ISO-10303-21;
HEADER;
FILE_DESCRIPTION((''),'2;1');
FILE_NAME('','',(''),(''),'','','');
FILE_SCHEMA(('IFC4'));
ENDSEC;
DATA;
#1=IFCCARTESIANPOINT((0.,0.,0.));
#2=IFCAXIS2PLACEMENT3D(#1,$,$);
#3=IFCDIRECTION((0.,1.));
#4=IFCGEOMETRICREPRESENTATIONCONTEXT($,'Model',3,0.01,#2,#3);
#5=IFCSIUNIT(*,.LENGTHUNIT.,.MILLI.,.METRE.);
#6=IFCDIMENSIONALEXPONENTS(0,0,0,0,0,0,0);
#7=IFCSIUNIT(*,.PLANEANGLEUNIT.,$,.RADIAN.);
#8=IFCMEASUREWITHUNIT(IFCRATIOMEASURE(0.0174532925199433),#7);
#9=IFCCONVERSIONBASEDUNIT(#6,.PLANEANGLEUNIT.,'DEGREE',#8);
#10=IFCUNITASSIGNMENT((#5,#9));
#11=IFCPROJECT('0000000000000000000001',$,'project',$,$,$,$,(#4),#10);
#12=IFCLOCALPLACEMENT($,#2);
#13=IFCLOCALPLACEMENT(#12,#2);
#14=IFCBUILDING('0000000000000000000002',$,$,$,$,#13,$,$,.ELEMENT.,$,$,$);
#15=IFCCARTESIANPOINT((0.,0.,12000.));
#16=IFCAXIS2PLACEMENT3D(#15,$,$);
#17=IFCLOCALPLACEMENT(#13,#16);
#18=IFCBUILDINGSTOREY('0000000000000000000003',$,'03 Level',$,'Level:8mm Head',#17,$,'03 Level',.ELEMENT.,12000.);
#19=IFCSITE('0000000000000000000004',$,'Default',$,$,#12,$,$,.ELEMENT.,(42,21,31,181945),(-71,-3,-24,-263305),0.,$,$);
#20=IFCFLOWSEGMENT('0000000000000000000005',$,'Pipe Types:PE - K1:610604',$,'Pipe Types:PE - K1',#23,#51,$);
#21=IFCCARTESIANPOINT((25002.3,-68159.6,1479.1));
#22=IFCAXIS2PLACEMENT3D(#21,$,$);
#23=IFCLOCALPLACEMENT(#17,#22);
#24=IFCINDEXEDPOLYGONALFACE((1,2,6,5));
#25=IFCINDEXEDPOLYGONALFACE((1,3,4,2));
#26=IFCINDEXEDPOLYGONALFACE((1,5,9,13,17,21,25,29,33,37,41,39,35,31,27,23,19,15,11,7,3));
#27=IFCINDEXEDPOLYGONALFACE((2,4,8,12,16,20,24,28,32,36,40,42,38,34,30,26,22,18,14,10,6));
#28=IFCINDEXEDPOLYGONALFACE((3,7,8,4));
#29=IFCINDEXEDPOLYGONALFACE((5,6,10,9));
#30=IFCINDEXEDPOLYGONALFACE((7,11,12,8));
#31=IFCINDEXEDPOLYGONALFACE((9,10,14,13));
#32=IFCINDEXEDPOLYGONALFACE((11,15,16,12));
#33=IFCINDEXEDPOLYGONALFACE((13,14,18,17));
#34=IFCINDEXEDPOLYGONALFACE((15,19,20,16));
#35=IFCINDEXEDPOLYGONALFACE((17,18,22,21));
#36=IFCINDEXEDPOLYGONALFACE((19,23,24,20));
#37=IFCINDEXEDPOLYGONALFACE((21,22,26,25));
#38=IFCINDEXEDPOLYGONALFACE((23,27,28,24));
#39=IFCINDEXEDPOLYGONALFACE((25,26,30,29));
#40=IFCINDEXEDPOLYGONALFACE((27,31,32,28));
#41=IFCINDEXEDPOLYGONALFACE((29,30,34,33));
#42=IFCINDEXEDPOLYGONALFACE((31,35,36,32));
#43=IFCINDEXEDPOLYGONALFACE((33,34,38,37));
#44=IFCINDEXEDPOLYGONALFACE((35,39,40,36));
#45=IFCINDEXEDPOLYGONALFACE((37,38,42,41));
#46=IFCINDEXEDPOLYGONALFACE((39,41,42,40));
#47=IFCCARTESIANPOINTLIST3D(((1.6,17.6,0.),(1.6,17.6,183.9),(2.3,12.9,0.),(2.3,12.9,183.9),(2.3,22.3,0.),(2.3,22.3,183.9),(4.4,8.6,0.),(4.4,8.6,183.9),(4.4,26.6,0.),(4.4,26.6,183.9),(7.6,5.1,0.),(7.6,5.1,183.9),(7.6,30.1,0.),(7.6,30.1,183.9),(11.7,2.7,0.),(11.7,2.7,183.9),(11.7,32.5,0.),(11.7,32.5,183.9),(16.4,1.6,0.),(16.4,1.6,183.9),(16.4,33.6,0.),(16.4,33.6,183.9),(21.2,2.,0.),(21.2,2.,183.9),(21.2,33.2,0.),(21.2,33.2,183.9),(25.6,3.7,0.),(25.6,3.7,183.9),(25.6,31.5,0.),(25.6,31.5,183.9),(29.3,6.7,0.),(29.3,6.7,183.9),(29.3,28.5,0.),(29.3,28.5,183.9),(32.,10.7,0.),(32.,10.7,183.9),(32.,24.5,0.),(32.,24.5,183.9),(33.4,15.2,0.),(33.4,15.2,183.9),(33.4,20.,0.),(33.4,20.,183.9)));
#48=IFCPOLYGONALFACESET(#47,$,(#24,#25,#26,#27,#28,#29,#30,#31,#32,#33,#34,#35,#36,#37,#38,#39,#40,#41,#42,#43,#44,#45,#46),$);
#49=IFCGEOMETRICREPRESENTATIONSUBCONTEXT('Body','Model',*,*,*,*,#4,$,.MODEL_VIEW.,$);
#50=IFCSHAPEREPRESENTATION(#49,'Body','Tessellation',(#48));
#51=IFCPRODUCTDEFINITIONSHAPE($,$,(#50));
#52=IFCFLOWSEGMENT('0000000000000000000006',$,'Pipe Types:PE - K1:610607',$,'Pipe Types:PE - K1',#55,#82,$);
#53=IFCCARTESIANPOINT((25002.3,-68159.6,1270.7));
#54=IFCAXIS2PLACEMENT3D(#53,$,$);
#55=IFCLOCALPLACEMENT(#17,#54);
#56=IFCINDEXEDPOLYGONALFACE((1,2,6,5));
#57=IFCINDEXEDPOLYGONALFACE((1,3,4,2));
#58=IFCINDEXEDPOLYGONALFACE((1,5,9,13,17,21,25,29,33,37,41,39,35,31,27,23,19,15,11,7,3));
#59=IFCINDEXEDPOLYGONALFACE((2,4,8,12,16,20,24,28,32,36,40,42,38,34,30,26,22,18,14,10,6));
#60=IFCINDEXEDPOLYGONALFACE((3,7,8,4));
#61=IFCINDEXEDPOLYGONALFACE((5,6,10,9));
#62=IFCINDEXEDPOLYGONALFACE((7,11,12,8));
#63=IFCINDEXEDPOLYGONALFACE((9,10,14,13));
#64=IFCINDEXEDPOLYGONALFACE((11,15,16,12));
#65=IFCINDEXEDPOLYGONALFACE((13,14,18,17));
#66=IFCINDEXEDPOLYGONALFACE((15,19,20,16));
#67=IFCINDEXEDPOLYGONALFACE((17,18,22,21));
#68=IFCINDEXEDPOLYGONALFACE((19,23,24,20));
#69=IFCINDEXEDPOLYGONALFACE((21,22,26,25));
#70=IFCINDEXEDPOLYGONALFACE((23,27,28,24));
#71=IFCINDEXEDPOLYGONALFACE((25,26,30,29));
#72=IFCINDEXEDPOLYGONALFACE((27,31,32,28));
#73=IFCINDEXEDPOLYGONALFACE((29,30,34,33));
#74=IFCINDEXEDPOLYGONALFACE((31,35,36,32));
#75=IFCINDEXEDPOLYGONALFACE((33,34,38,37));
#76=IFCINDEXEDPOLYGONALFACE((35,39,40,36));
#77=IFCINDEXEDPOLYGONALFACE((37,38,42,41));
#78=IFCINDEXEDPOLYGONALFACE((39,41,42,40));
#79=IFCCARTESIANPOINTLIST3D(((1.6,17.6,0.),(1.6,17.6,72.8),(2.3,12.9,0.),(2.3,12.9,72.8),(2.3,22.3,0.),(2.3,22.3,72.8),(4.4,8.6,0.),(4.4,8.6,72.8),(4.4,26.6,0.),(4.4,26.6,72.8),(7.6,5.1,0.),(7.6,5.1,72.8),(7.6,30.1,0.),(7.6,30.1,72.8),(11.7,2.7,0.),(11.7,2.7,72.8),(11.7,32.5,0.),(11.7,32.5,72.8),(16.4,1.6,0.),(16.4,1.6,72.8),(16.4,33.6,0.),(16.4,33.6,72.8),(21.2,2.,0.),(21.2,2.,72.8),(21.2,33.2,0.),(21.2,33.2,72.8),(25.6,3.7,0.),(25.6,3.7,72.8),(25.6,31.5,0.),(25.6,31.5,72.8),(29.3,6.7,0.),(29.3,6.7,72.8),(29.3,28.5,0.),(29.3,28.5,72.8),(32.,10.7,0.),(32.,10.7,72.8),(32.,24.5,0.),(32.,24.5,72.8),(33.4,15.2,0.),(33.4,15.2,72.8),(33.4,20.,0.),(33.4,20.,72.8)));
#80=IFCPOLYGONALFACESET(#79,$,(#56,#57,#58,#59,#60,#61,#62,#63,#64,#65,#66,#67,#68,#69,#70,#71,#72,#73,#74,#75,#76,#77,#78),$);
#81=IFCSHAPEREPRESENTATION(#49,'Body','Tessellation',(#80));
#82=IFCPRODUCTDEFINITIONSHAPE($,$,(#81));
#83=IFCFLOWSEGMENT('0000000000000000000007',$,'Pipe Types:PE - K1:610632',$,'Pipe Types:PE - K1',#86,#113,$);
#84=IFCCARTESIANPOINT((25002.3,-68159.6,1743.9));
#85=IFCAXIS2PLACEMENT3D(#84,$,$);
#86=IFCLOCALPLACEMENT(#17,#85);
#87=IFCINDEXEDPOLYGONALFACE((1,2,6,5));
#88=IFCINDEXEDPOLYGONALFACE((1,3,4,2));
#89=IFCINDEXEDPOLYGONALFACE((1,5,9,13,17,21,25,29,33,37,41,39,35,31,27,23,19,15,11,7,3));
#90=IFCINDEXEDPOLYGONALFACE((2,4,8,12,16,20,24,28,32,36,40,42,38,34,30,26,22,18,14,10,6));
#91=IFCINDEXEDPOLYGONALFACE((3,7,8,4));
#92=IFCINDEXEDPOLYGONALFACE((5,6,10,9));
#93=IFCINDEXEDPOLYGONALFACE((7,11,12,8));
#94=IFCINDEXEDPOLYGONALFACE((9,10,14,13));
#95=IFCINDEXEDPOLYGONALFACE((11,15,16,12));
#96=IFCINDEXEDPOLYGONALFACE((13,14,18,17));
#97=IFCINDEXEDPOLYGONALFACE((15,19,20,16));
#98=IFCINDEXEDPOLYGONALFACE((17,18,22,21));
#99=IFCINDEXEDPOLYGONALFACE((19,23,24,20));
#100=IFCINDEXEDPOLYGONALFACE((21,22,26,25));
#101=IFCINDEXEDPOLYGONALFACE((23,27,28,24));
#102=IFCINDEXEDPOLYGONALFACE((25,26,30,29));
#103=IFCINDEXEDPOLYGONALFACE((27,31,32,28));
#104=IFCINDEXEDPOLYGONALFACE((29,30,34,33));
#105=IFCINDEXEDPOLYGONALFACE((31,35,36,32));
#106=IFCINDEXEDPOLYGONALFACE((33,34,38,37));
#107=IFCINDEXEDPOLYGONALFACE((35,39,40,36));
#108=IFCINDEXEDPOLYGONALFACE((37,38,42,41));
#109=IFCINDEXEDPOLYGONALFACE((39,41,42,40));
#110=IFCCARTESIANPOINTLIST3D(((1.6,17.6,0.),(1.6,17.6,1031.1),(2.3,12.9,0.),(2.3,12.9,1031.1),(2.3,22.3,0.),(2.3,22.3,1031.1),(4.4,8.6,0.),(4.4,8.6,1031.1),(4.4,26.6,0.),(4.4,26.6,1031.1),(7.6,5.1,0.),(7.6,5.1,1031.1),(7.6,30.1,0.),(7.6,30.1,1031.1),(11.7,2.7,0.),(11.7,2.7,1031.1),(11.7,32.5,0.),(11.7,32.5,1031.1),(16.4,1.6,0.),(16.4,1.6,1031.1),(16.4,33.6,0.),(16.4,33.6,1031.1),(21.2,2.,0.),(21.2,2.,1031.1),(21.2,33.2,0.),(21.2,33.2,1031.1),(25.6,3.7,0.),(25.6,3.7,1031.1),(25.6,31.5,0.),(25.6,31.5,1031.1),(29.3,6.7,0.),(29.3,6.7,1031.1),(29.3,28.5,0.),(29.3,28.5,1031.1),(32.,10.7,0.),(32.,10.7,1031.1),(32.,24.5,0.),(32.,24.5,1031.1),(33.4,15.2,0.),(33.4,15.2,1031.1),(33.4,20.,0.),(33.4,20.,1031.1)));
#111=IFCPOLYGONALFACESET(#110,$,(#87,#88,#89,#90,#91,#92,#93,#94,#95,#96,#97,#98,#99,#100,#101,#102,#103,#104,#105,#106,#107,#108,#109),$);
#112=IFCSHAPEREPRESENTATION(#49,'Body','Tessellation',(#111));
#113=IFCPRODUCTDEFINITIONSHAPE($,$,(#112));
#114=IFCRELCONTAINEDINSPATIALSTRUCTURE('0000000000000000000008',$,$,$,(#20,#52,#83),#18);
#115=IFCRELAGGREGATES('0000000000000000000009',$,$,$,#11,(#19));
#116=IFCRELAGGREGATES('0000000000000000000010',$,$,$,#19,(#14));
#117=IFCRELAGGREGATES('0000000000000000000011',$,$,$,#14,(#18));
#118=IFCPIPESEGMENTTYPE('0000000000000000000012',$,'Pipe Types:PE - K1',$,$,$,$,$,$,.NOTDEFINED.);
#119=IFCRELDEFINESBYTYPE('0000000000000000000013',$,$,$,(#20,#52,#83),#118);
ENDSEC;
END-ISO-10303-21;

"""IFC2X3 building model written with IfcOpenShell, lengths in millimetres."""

from ifc_helpers import new_model, entity, si_unit, converted_unit, direction, frame, origin, origin_2d_with_axis, place, context, subcontext, project, spatial, circle, extrude, type_object, element, save


model = new_model("IFC2X3")

# Units and contexts
model_context = context("Model", 3, precision=0.01, world=origin(), true_north=direction((0.0, 1.0)))
body_context = subcontext(model_context, "Body", "Model", "MODEL_VIEW")
ifc_project = project(units=[si_unit("LENGTHUNIT", "METRE", prefix="MILLI"), converted_unit("PLANEANGLEUNIT", "DEGREE", entity("IfcRatioMeasure", 0.0174532925199433), si_unit("PLANEANGLEUNIT", "RADIAN"), dimensions=[0, 0, 0, 0, 0, 0, 0])], contexts=[model_context])

# Site, building, storey
site_placement = place(None, origin())
site = spatial("IfcSite", under=ifc_project, at=site_placement, Name="Default", CompositionType="ELEMENT", RefLatitude=(42, 21, 31, 181945), RefLongitude=(-71, -3, -24, -263305), RefElevation=0.0)
building_placement = place(site_placement, origin())
building = spatial("IfcBuilding", under=site, at=building_placement, CompositionType="ELEMENT")
storey_placement = place(building_placement, frame((0.0, 0.0, 12000.0)))
storey = spatial("IfcBuildingStorey", under=building, at=storey_placement, Name="03 Level", ObjectType="Level:8mm Head", LongName="03 Level", CompositionType="ELEMENT", Elevation=12000.0)

# Flow segments
pipe_segment_type = type_object("IfcPipeSegmentType", Name="Pipe Types:PE - K1", PredefinedType="NOTDEFINED")
flow_segment_1_placement = place(storey_placement, frame((25002.3, -68159.6, 1479.1)))
element("IfcFlowSegment", 1, at=flow_segment_1_placement, inside=storey, type_object=pipe_segment_type, Name="Pipe Types:PE - K1:610604", ObjectType="Pipe Types:PE - K1", context=body_context, shape_type="SweptSolid", body=[
    extrude(circle(Radius=16.0, at=origin_2d_with_axis()), frame((17.6, 17.6, 0.0), z_axis=(0.0, 0.0, 1.0), x_axis=(-1.0, 0.0, 0.0)), (0.0, 0.0, 1.0), 183.9),
])
flow_segment_2_placement = place(storey_placement, frame((25002.3, -68159.6, 1270.7)))
element("IfcFlowSegment", 2, at=flow_segment_2_placement, inside=storey, type_object=pipe_segment_type, Name="Pipe Types:PE - K1:610607", ObjectType="Pipe Types:PE - K1", context=body_context, shape_type="SweptSolid", body=[
    extrude(circle(Radius=16.0, at=origin_2d_with_axis()), frame((17.6, 17.6, 0.0), z_axis=(0.0, 0.0, 1.0), x_axis=(-1.0, 0.0, 0.0)), (0.0, 0.0, 1.0), 72.8),
])
flow_segment_3_placement = place(storey_placement, frame((25002.3, -68159.6, 1743.9)))
element("IfcFlowSegment", 3, at=flow_segment_3_placement, inside=storey, type_object=pipe_segment_type, Name="Pipe Types:PE - K1:610632", ObjectType="Pipe Types:PE - K1", context=body_context, shape_type="SweptSolid", body=[
    extrude(circle(Radius=16.0, at=origin_2d_with_axis()), frame((17.6, 17.6, 0.0), z_axis=(0.0, 0.0, 1.0), x_axis=(-1.0, 0.0, 0.0)), (0.0, 0.0, 1.0), 1031.1),
])

save(model, "model.ifc")
